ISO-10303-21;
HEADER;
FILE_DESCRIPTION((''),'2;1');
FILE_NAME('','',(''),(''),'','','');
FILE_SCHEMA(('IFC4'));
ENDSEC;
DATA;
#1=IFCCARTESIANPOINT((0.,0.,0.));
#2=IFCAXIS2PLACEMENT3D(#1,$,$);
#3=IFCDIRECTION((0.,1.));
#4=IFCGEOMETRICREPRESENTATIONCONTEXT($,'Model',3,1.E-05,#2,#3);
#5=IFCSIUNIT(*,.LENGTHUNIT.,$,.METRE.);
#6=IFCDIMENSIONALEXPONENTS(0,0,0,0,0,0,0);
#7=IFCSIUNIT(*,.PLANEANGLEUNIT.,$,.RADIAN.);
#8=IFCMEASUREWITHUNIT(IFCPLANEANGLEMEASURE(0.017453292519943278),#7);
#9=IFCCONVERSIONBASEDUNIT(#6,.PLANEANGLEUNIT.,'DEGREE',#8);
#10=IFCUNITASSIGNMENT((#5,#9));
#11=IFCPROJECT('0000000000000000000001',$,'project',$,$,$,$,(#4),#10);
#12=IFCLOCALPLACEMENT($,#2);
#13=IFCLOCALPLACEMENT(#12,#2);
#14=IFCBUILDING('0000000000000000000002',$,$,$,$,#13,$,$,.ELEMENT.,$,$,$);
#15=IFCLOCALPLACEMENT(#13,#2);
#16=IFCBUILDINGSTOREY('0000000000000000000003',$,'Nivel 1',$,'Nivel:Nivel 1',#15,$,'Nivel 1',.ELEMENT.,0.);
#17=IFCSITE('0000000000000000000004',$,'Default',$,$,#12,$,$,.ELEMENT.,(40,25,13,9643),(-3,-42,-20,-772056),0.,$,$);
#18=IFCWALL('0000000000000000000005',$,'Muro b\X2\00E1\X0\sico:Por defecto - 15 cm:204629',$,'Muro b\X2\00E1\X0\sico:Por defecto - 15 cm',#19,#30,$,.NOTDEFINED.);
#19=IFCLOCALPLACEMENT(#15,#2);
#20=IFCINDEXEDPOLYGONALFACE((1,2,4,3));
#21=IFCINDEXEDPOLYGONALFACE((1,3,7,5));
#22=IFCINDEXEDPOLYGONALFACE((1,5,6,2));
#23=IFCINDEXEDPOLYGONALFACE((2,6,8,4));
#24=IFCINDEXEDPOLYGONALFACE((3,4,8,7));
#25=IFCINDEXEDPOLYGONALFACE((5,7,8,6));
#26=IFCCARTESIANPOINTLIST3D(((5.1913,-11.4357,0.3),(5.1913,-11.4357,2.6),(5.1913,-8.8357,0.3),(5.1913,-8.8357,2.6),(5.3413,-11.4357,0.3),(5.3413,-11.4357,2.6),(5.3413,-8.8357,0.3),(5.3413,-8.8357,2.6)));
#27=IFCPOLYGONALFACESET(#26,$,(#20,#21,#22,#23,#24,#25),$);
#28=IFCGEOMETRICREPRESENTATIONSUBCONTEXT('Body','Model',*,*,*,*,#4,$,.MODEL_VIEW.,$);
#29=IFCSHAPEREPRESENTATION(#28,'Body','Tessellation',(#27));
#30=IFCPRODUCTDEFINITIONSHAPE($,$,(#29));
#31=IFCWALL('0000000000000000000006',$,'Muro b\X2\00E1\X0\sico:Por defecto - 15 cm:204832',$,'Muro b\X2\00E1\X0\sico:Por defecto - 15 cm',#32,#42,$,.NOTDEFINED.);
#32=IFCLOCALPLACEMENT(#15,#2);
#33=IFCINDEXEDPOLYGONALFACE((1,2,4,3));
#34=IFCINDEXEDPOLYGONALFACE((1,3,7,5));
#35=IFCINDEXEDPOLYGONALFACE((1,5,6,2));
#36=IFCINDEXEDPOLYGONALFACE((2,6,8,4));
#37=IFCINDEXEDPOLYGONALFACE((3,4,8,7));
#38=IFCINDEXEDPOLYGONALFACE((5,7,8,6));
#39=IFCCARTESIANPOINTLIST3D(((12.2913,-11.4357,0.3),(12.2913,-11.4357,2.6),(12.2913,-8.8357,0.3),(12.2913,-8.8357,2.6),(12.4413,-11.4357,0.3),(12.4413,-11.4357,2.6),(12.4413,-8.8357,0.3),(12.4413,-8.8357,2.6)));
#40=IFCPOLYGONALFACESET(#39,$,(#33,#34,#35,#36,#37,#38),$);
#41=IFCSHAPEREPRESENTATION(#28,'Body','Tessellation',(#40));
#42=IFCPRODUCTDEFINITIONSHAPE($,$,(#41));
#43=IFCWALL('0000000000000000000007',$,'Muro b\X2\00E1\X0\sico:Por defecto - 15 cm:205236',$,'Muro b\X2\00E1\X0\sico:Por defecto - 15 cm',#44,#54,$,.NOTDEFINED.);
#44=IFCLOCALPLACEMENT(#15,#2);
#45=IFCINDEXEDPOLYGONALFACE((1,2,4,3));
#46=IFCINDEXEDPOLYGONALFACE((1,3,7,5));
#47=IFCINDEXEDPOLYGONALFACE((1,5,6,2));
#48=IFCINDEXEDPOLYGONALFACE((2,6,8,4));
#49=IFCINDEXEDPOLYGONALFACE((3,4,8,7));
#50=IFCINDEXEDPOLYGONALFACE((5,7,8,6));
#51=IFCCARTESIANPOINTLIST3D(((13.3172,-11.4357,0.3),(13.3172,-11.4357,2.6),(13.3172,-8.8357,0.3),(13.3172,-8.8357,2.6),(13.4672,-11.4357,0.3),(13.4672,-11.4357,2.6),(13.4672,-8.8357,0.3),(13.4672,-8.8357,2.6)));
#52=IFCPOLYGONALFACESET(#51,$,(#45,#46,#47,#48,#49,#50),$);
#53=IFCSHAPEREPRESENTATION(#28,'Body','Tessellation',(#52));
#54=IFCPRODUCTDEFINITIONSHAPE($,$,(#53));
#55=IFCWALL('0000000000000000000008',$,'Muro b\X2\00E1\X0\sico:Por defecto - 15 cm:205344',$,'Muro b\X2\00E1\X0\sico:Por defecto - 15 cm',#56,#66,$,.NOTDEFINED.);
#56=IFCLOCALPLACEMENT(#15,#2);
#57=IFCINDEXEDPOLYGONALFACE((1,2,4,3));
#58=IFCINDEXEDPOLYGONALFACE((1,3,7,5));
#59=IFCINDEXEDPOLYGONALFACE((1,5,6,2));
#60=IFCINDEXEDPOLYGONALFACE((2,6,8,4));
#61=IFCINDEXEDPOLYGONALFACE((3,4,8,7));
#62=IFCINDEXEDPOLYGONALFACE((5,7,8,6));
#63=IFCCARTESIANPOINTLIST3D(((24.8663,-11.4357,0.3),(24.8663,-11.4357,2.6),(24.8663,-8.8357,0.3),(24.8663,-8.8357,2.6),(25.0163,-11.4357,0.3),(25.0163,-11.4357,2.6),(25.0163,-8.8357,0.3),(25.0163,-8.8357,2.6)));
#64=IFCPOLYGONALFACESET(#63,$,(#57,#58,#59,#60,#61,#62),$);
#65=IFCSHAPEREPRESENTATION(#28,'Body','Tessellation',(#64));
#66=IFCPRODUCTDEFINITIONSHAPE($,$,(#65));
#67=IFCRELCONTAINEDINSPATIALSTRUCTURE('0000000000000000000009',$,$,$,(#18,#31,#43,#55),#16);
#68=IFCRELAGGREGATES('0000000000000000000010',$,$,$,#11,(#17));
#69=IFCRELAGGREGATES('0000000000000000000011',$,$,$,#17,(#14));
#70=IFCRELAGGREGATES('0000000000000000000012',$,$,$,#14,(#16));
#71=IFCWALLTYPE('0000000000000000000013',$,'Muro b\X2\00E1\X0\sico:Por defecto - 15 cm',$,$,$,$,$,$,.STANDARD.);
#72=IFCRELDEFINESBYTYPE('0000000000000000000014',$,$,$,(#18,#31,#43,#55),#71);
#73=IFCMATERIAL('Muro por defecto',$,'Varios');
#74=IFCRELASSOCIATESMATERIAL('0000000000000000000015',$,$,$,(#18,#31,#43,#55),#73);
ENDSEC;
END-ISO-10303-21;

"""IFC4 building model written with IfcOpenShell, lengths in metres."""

from ifc_helpers import new_model, entity, si_unit, converted_unit, direction, frame, origin, place, context, subcontext, project, spatial, indexed_curve, outline, extrude, material, type_object, element, save


model = new_model("IFC4")

# Units and contexts
model_context = context("Model", 3, precision=1e-05, world=origin(), true_north=direction((0.0, 1.0)))
body_context = subcontext(model_context, "Body", "Model", "MODEL_VIEW")
ifc_project = project(units=[si_unit("LENGTHUNIT", "METRE"), converted_unit("PLANEANGLEUNIT", "DEGREE", entity("IfcPlaneAngleMeasure", 0.017453292519943278), si_unit("PLANEANGLEUNIT", "RADIAN"), dimensions=[0, 0, 0, 0, 0, 0, 0])], contexts=[model_context])

# Site, building, storey
site_placement = place(None, origin())
site = spatial("IfcSite", under=ifc_project, at=site_placement, Name="Default", CompositionType="ELEMENT", RefLatitude=(40, 25, 13, 9643), RefLongitude=(-3, -42, -20, -772056), RefElevation=0.0)
building_placement = place(site_placement, origin())
building = spatial("IfcBuilding", under=site, at=building_placement, CompositionType="ELEMENT")
storey_placement = place(building_placement, origin())
storey = spatial("IfcBuildingStorey", under=building, at=storey_placement, Name="Nivel 1", ObjectType="Nivel:Nivel 1", LongName="Nivel 1", CompositionType="ELEMENT", Elevation=0.0)

# Walls
ifc_material_1 = material(Name="Muro por defecto", Category="Varios")
wall_type_1 = type_object("IfcWallType", Name="Muro básico:Por defecto - 15 cm", PredefinedType="STANDARD")
for number, where, z_axis, x_axis, name in (
    (1, (5.2663, -8.8357, 0.3), (0.0, 0.0, 1.0), (0.0, -1.0, 0.0), "Muro básico:Por defecto - 15 cm:204629"),
    (2, (12.3663, -8.8357, 0.3), (0.0, 0.0, 1.0), (0.0, -1.0, 0.0), "Muro básico:Por defecto - 15 cm:204832"),
):
    element("IfcWall", number, at=place(storey_placement, frame(where, z_axis=z_axis, x_axis=x_axis)), inside=storey, type_object=wall_type_1, material=ifc_material_1, Name=name, ObjectType="Muro básico:Por defecto - 15 cm", PredefinedType="NOTDEFINED", context=body_context, shape_type="SweptSolid", body=[
        extrude(outline(indexed_curve([(2.6, 0.075), (0.0, 0.075), (0.0, -0.075), (2.6, -0.075), (2.6, 0.075)], self_intersect=False)), origin(), (0.0, 0.0, 1.0), 2.3),
    ])
wall_1_placement = place(storey_placement, frame((13.3922, -8.8357, 0.3), z_axis=(0.0, 0.0, 1.0), x_axis=(0.0, -1.0, 0.0)))
element("IfcWall", 3, at=wall_1_placement, inside=storey, type_object=wall_type_1, material=ifc_material_1, Name="Muro básico:Por defecto - 15 cm:205236", ObjectType="Muro básico:Por defecto - 15 cm", PredefinedType="NOTDEFINED", context=body_context, shape_type="SweptSolid", body=[
    extrude(outline(indexed_curve([(2.6, 0.075), (0.0, 0.075), (0.0, -0.075), (2.6, -0.075), (2.6, 0.075)], self_intersect=False)), origin(), (0.0, 0.0, 1.0), 2.3),
])
wall_2_placement = place(storey_placement, frame((24.9413, -8.8357, 0.3), z_axis=(0.0, 0.0, 1.0), x_axis=(0.0, -1.0, 0.0)))
element("IfcWall", 4, at=wall_2_placement, inside=storey, type_object=wall_type_1, material=ifc_material_1, Name="Muro básico:Por defecto - 15 cm:205344", ObjectType="Muro básico:Por defecto - 15 cm", PredefinedType="NOTDEFINED", context=body_context, shape_type="SweptSolid", body=[
    extrude(outline(indexed_curve([(2.6, 0.075), (0.0, 0.075), (0.0, -0.075), (2.6, -0.075), (2.6, 0.075)], self_intersect=False)), origin(), (0.0, 0.0, 1.0), 2.3),
])

save(model, "model.ifc")
